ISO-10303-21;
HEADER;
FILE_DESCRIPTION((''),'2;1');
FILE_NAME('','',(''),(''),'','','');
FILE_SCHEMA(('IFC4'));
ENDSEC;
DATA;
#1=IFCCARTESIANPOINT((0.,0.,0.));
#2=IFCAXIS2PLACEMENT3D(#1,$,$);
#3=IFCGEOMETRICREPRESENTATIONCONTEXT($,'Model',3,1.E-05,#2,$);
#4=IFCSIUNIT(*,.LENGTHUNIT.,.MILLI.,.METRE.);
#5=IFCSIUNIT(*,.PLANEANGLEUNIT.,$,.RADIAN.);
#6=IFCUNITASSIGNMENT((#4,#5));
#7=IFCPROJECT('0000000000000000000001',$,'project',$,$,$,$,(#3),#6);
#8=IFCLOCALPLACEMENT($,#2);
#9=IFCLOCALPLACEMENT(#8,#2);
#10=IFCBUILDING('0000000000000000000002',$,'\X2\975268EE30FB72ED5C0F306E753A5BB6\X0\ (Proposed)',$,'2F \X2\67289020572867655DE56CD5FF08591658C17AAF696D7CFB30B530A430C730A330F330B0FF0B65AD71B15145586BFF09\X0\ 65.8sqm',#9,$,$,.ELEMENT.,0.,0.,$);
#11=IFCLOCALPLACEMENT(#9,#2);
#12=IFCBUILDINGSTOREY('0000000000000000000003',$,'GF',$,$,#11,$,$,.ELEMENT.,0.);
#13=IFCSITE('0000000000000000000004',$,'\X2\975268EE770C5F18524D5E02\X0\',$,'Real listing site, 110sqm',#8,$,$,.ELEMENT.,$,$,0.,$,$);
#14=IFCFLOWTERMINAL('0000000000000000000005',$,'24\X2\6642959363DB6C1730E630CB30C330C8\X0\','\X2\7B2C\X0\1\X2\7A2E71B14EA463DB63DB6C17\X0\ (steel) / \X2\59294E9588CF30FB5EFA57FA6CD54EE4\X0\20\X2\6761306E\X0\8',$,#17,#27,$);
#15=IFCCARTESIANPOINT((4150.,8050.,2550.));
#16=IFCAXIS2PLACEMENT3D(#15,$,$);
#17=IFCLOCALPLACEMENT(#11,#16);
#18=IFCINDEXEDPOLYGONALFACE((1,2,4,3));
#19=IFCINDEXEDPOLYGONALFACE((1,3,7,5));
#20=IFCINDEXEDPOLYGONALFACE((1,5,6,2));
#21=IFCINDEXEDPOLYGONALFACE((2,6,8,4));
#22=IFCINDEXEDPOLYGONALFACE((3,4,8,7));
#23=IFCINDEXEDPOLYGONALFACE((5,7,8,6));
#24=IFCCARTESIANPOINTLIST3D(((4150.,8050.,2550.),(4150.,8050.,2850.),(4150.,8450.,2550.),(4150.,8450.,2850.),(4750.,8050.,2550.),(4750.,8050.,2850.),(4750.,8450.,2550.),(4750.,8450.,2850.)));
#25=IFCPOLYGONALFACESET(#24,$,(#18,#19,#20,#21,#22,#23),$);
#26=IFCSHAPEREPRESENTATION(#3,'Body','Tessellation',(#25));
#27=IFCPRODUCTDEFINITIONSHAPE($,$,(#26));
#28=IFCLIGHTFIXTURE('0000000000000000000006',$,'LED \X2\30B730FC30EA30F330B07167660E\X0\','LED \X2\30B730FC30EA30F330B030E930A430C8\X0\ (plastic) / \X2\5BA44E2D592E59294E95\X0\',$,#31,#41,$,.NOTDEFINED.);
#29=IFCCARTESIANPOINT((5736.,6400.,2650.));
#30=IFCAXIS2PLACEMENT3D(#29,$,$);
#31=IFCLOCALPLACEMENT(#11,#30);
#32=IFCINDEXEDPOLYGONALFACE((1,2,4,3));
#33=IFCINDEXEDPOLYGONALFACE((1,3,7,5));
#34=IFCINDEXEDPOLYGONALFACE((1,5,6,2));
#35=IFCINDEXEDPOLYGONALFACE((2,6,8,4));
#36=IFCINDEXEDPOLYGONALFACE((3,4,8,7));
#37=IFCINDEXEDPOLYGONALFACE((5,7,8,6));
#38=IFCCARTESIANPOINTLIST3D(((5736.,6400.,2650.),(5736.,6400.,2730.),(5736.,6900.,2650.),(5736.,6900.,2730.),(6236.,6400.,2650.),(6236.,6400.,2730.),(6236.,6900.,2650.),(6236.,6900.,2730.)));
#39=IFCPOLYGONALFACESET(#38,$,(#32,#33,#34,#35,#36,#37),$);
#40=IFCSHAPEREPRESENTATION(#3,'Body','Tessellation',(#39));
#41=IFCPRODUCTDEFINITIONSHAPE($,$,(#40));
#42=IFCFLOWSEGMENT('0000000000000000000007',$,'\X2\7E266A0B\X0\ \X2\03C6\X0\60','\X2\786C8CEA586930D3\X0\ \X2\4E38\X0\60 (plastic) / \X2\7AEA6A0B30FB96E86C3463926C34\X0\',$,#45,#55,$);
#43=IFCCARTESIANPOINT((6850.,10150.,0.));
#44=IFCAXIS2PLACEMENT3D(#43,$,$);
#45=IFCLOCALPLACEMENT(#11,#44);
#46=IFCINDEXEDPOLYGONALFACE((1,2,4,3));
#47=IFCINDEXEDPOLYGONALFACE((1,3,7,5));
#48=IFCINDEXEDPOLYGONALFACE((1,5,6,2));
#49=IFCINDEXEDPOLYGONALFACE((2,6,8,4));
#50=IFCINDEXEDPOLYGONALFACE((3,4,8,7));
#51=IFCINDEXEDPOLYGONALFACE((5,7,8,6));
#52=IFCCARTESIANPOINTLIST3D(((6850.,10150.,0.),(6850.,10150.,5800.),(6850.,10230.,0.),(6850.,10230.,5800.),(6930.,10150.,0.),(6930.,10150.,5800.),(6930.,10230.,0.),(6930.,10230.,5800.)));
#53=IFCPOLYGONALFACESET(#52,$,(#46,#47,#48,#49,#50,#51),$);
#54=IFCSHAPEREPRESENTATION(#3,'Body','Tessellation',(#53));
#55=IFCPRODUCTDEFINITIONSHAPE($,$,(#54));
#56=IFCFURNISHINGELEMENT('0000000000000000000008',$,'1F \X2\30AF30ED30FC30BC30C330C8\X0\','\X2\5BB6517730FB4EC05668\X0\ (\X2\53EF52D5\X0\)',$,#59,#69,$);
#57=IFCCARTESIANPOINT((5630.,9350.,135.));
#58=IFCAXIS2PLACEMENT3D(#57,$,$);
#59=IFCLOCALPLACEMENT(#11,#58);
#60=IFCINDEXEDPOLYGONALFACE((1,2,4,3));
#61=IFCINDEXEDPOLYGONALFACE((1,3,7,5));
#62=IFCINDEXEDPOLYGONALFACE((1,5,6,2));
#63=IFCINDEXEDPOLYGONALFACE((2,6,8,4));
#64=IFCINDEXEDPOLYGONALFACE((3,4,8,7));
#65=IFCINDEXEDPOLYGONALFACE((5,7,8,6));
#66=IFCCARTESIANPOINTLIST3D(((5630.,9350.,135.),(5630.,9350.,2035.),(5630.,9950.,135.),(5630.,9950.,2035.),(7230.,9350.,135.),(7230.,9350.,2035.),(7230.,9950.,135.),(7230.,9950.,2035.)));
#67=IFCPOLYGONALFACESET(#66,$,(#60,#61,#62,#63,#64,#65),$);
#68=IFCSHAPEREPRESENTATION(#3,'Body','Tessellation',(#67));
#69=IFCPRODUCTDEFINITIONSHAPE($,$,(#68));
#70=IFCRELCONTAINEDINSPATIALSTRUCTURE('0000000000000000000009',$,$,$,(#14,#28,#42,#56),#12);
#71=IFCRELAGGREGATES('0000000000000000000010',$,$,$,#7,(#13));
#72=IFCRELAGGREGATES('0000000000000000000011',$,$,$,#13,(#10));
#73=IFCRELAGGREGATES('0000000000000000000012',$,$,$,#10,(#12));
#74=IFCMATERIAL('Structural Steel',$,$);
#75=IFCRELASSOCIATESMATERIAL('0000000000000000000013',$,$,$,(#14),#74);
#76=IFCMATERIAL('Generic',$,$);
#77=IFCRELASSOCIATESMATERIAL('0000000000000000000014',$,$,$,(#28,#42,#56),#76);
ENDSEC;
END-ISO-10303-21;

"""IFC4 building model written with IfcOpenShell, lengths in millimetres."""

from ifc_helpers import new_model, si_unit, frame, frame_2d, origin, place, context, project, spatial, rectangle, extrude, material, element, save


model = new_model("IFC4")

# Units and contexts
model_context = context("Model", 3, precision=1e-05, world=origin())
ifc_project = project(units=[si_unit("LENGTHUNIT", "METRE", prefix="MILLI"), si_unit("PLANEANGLEUNIT", "RADIAN")], contexts=[model_context])

# Site, building, storey
site_placement = place(None, origin())
site = spatial("IfcSite", under=ifc_project, at=site_placement, Name="青森県弘前市", ObjectType="Real listing site, 110sqm", CompositionType="ELEMENT", RefElevation=0.0)
building_placement = place(site_placement, origin())
building = spatial("IfcBuilding", under=site, at=building_placement, Name="青森・狭小の町家 (Proposed)", ObjectType="2F 木造在来工法（外壁窯業系サイディング＋断熱充填） 65.8sqm", CompositionType="ELEMENT", ElevationOfRefHeight=0.0, ElevationOfTerrain=0.0)
storey_placement = place(building_placement, origin())
storey = spatial("IfcBuildingStorey", under=building, at=storey_placement, Name="GF", CompositionType="ELEMENT", Elevation=0.0)

# Shared definitions
ifc_material_1 = material(Name="Generic")

# Flow terminal
ifc_material_2 = material(Name="Structural Steel")
flow_terminal_placement = place(storey_placement, frame((4150.0, 8050.0, 2550.0)))
element("IfcFlowTerminal", 1, at=flow_terminal_placement, inside=storey, material=ifc_material_2, Name="24時間換気ユニット", Description="第1種熱交換換気 (steel) / 天井裏・建基法令20条の8", context=model_context, shape_type="SweptSolid", body=[
    extrude(rectangle(XDim=600.0, YDim=400.0, at=frame_2d((300.0, 200.0))), frame((4150.0, 8050.0, 2550.0)), (0.0, 0.0, 1.0), 300.0),
])

# Light fixture
light_fixture_placement = place(storey_placement, frame((5736.0, 6400.0, 2650.0)))
element("IfcLightFixture", 2, at=light_fixture_placement, inside=storey, material=ifc_material_1, Name="LED シーリング照明", Description="LED シーリングライト (plastic) / 室中央天井", PredefinedType="NOTDEFINED", context=model_context, shape_type="SweptSolid", body=[
    extrude(rectangle(XDim=500.0, YDim=500.0, at=frame_2d((250.0, 250.0))), frame((5736.0, 6400.0, 2650.0)), (0.0, 0.0, 1.0), 80.0),
])

# Flow segment
flow_segment_placement = place(storey_placement, frame((6850.0, 10150.0, 0.0)))
element("IfcFlowSegment", 3, at=flow_segment_placement, inside=storey, material=ifc_material_1, Name="縦樋 φ60", Description="硬質塩ビ 丸60 (plastic) / 竪樋・雨水排水", context=model_context, shape_type="SweptSolid", body=[
    extrude(rectangle(XDim=80.0, YDim=80.0, at=frame_2d((40.0, 40.0))), frame((6850.0, 10150.0, 0.0)), (0.0, 0.0, 1.0), 5800.0),
])

# Furnishing element
furnishing_placement = place(storey_placement, frame((5630.0, 9350.0, 135.0)))
element("IfcFurnishingElement", 4, at=furnishing_placement, inside=storey, material=ifc_material_1, Name="1F クローゼット", Description="家具・什器 (可動)", context=model_context, shape_type="SweptSolid", body=[
    extrude(rectangle(XDim=1600.0, YDim=600.0, at=frame_2d((800.0, 300.0))), frame((5630.0, 9350.0, 135.0)), (0.0, 0.0, 1.0), 1900.0),
])

save(model, "model.ifc")
